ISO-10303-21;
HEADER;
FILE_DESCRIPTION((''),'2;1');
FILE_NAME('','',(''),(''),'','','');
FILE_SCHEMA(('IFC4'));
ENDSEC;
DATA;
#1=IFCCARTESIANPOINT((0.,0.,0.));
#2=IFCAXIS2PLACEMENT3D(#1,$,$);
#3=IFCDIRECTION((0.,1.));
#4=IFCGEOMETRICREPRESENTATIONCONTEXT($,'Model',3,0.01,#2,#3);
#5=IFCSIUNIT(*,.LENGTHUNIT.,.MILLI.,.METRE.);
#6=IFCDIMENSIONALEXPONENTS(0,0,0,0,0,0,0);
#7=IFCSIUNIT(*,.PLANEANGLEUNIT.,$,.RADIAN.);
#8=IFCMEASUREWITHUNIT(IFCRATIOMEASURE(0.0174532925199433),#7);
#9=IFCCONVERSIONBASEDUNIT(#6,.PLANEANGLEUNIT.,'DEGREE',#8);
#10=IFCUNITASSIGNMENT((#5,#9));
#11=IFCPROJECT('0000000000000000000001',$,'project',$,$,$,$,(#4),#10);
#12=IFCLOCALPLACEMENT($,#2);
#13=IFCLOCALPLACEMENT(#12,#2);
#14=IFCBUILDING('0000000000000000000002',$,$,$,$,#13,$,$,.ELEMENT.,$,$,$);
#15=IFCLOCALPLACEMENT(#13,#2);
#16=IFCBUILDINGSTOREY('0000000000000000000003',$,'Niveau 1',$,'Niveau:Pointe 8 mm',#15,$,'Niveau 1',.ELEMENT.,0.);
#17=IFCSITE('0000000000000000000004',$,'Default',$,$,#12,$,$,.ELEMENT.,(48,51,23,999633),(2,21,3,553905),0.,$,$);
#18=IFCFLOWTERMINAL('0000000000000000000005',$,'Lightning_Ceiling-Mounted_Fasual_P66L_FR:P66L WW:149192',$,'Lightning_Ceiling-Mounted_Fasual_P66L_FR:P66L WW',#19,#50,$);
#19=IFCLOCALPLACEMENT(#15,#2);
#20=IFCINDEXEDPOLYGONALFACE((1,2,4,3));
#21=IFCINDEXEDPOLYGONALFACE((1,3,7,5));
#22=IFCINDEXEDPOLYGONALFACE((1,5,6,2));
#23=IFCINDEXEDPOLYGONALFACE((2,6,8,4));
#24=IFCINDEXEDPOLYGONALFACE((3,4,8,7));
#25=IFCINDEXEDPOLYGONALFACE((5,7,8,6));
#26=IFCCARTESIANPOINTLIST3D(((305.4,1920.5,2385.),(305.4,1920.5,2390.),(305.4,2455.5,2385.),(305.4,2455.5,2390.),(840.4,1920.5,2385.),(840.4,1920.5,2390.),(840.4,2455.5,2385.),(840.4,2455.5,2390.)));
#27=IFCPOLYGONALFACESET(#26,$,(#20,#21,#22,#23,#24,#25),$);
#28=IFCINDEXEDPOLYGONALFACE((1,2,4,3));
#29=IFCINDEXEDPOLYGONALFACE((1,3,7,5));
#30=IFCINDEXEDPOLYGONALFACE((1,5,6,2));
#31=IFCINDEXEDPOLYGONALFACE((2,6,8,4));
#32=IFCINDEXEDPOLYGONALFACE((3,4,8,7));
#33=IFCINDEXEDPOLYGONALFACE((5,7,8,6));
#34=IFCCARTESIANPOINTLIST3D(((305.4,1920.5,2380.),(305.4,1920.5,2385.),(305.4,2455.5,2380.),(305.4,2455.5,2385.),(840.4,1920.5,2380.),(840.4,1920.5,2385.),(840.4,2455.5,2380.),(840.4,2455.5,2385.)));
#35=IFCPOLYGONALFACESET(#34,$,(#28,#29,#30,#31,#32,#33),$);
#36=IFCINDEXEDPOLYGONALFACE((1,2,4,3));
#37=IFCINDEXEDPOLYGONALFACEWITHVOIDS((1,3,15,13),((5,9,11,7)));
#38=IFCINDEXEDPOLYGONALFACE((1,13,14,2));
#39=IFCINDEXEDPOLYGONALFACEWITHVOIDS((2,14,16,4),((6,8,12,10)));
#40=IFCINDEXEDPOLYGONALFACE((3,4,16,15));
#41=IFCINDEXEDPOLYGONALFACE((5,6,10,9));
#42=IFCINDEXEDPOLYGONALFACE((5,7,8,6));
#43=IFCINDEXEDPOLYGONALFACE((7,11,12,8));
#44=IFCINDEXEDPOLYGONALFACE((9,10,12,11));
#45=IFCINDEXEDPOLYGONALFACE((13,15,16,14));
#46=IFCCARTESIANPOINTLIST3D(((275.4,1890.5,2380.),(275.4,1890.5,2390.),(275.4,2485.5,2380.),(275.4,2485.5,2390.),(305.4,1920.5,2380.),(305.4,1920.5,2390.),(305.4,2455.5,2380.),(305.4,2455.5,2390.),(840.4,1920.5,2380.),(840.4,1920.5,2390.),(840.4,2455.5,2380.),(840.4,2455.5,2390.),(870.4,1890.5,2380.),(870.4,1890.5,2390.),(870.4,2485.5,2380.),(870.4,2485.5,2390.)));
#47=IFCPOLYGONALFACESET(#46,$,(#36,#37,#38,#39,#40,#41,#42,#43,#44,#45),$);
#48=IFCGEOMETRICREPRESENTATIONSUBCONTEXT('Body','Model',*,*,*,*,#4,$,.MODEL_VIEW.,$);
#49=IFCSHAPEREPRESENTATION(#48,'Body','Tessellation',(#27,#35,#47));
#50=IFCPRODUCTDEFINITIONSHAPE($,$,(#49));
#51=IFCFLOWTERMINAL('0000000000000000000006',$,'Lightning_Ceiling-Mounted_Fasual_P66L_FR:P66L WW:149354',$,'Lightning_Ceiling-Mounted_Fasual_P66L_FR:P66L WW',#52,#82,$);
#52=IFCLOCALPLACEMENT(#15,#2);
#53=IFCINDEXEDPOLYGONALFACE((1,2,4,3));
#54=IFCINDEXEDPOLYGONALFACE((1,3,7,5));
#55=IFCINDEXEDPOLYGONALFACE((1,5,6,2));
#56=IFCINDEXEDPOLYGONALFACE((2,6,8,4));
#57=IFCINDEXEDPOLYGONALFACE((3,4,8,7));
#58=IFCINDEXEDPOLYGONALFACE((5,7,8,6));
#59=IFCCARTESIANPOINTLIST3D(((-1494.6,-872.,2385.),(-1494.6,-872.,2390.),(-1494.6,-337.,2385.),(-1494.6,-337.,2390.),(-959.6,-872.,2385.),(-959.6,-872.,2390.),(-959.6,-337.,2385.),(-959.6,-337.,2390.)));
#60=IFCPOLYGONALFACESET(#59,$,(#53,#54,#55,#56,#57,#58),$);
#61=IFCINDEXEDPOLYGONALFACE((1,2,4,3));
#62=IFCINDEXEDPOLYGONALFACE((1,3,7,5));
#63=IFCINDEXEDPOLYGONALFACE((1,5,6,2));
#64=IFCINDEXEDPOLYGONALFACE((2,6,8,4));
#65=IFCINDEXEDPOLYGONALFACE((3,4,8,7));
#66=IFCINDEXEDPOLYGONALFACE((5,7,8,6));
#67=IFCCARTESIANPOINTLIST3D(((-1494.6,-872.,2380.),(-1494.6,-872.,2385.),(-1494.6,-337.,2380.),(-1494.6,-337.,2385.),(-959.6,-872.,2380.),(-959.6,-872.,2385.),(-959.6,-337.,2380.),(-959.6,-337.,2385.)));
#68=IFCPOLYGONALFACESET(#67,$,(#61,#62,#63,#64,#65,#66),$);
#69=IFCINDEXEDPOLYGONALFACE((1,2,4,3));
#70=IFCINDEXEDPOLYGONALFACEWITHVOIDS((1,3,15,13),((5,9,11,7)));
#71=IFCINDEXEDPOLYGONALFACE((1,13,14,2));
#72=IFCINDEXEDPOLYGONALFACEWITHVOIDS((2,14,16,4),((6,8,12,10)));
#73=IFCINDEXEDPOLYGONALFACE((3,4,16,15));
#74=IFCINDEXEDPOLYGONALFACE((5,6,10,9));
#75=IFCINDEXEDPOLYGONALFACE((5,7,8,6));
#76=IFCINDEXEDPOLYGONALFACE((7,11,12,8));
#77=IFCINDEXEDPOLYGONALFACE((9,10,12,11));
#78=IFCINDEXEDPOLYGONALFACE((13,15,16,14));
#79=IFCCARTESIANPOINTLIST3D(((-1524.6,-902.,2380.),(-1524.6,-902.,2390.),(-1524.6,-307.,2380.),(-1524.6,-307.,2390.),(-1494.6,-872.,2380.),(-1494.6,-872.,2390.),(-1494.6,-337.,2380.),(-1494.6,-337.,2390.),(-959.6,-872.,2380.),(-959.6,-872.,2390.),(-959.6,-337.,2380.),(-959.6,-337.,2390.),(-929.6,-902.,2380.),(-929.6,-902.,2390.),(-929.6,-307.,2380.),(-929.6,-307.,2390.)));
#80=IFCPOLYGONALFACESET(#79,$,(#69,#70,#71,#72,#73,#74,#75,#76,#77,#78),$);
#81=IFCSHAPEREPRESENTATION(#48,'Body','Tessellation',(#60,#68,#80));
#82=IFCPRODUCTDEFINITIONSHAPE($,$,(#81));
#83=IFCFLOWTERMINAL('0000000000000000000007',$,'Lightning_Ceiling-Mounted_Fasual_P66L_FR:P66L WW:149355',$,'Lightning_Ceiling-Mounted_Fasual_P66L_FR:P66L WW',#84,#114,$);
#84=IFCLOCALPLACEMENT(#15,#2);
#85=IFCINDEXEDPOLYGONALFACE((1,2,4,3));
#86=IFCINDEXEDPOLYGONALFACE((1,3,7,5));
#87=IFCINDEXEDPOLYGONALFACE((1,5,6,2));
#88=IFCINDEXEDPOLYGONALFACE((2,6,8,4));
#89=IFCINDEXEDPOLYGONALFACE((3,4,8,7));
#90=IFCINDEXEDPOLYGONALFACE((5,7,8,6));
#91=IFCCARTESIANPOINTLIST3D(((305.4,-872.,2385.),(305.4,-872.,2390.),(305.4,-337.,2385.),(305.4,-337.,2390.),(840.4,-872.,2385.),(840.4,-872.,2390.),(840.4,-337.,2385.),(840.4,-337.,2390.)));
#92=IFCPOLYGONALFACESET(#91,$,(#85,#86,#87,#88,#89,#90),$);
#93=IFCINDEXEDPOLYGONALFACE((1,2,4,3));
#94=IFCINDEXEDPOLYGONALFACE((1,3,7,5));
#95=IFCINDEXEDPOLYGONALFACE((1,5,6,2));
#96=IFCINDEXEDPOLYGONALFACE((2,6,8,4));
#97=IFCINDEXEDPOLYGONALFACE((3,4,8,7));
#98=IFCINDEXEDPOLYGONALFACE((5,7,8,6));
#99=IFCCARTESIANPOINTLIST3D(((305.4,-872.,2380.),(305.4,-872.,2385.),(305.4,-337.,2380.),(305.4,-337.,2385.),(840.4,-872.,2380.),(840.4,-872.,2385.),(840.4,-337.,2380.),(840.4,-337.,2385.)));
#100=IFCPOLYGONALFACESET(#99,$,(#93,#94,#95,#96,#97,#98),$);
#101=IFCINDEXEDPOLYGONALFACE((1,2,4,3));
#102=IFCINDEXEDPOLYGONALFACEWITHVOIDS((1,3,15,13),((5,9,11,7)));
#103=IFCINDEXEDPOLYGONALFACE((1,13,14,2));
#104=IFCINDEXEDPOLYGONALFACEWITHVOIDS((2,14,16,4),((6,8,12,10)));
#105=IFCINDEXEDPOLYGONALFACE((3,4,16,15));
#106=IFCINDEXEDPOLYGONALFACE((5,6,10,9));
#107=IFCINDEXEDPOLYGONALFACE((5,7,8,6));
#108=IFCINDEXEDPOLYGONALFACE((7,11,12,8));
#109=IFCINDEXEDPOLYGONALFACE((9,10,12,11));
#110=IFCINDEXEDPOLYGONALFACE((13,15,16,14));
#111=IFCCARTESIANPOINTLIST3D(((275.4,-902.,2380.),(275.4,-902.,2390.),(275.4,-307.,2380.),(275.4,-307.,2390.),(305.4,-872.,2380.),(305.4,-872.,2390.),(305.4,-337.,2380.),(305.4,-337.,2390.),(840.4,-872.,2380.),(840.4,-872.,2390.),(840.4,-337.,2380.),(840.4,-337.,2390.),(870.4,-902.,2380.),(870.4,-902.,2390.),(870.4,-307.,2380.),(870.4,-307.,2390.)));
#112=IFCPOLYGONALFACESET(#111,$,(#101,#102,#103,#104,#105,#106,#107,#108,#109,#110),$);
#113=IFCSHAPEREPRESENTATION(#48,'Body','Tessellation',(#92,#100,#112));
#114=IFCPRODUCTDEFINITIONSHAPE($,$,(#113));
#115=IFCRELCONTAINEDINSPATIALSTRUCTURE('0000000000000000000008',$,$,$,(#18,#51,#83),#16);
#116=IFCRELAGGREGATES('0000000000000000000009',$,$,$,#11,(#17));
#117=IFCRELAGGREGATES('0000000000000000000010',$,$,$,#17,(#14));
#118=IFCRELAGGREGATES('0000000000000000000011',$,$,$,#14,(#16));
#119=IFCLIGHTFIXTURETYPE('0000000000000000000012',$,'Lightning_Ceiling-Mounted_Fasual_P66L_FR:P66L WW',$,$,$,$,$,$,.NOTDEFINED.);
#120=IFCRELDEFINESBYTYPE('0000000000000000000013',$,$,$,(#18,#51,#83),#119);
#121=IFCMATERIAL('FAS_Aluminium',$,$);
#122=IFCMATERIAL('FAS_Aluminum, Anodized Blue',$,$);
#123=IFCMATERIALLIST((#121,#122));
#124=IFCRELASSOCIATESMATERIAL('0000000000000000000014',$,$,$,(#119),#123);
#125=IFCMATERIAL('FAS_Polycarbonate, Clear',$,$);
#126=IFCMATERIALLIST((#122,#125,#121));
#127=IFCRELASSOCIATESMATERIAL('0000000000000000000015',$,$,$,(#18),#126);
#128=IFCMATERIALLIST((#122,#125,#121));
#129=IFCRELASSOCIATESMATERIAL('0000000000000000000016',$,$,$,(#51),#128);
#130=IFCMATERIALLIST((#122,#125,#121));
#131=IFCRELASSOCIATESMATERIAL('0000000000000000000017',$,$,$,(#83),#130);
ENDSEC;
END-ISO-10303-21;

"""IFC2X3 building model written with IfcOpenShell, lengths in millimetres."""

from ifc_helpers import new_model, entity, si_unit, converted_unit, direction, frame, origin, origin_2d_with_axis, place, context, subcontext, project, spatial, polyline, rectangle, outline, extrude, source, transform, mapped, material, material_list, type_object, type_shapes, element, save


model = new_model("IFC2X3")

# Units and contexts
model_context = context("Model", 3, precision=0.01, world=origin(), true_north=direction((0.0, 1.0)))
body_context = subcontext(model_context, "Body", "Model", "MODEL_VIEW")
ifc_project = project(units=[si_unit("LENGTHUNIT", "METRE", prefix="MILLI"), converted_unit("PLANEANGLEUNIT", "DEGREE", entity("IfcRatioMeasure", 0.0174532925199433), si_unit("PLANEANGLEUNIT", "RADIAN"), dimensions=[0, 0, 0, 0, 0, 0, 0])], contexts=[model_context])

# Site, building, storey
site_placement = place(None, origin())
site = spatial("IfcSite", under=ifc_project, at=site_placement, Name="Default", CompositionType="ELEMENT", RefLatitude=(48, 51, 23, 999633), RefLongitude=(2, 21, 3, 553905), RefElevation=0.0)
building_placement = place(site_placement, origin())
building = spatial("IfcBuilding", under=site, at=building_placement, CompositionType="ELEMENT")
storey_placement = place(building_placement, origin())
storey = spatial("IfcBuildingStorey", under=building, at=storey_placement, Name="Niveau 1", ObjectType="Niveau:Pointe 8 mm", LongName="Niveau 1", CompositionType="ELEMENT", Elevation=0.0)

# Flow terminals
ifc_material_1 = material(Name="FAS_Aluminum, Anodized Blue")
ifc_material_2 = material(Name="FAS_Polycarbonate, Clear")
ifc_material_3 = material(Name="FAS_Aluminium")
ifc_material_list_1 = material_list([ifc_material_3, ifc_material_1])
light_fixture_type = type_object("IfcLightFixtureType", Name="Lightning_Ceiling-Mounted_Fasual_P66L_FR:P66L WW", PredefinedType="NOTDEFINED", material=ifc_material_list_1)
shared_shape_1 = source(origin(), body_context, "Body", "SweptSolid", [
    extrude(rectangle(XDim=535.0, YDim=535.0, at=origin_2d_with_axis()), frame((0.0, 0.0, -10.0), z_axis=(0.0, 0.0, 1.0), x_axis=(0.0, 1.0, 0.0)), (0.0, 0.0, 1.0), 5.0),
    extrude(rectangle(XDim=535.0, YDim=535.0, at=origin_2d_with_axis()), frame((0.0, 0.0, -5.0), z_axis=(0.0, 0.0, 1.0), x_axis=(0.0, -1.0, 0.0)), (0.0, 0.0, 1.0), 5.0),
    extrude(outline(polyline([(-297.5, -297.5), (297.5, -297.5), (297.5, 297.5), (-297.5, 297.5), (-297.5, -297.5)]), holes=[polyline([(267.5, -267.5), (-267.5, -267.5), (-267.5, 267.5), (267.5, 267.5), (267.5, -267.5)])]), frame((0.0, 0.0, -10.0), z_axis=(0.0, 0.0, 1.0), x_axis=(0.0, 1.0, 0.0)), (0.0, 0.0, 1.0), 10.0),
])
type_shapes(light_fixture_type, [shared_shape_1])
ifc_material_list_2 = material_list([ifc_material_1, ifc_material_2, ifc_material_3])
flow_terminal_1_placement = place(storey_placement, frame((572.9, 2188.0, 2380.0), z_axis=(0.0, 0.0, -1.0), x_axis=(1.0, 0.0, 0.0)))
element("IfcFlowTerminal", 1, at=flow_terminal_1_placement, inside=storey, type_object=light_fixture_type, material=ifc_material_list_2, Name="Lightning_Ceiling-Mounted_Fasual_P66L_FR:P66L WW:149192", ObjectType="Lightning_Ceiling-Mounted_Fasual_P66L_FR:P66L WW", context=body_context, shape_type="MappedRepresentation", body=[
    mapped(shared_shape_1, transform((0.0, 0.0, 0.0), scale=1.0)),
])
ifc_material_list_3 = material_list([ifc_material_1, ifc_material_2, ifc_material_3])
flow_terminal_2_placement = place(storey_placement, frame((-1227.1, -604.5, 2380.0), z_axis=(0.0, 0.0, -1.0), x_axis=(1.0, 0.0, 0.0)))
element("IfcFlowTerminal", 2, at=flow_terminal_2_placement, inside=storey, type_object=light_fixture_type, material=ifc_material_list_3, Name="Lightning_Ceiling-Mounted_Fasual_P66L_FR:P66L WW:149354", ObjectType="Lightning_Ceiling-Mounted_Fasual_P66L_FR:P66L WW", context=body_context, shape_type="MappedRepresentation", body=[
    mapped(shared_shape_1, transform((0.0, 0.0, 0.0), scale=1.0)),
])
ifc_material_list_4 = material_list([ifc_material_1, ifc_material_2, ifc_material_3])
flow_terminal_3_placement = place(storey_placement, frame((572.9, -604.5, 2380.0), z_axis=(0.0, 0.0, -1.0), x_axis=(1.0, 0.0, 0.0)))
element("IfcFlowTerminal", 3, at=flow_terminal_3_placement, inside=storey, type_object=light_fixture_type, material=ifc_material_list_4, Name="Lightning_Ceiling-Mounted_Fasual_P66L_FR:P66L WW:149355", ObjectType="Lightning_Ceiling-Mounted_Fasual_P66L_FR:P66L WW", context=body_context, shape_type="MappedRepresentation", body=[
    mapped(shared_shape_1, transform((0.0, 0.0, 0.0), scale=1.0)),
])

save(model, "model.ifc")
